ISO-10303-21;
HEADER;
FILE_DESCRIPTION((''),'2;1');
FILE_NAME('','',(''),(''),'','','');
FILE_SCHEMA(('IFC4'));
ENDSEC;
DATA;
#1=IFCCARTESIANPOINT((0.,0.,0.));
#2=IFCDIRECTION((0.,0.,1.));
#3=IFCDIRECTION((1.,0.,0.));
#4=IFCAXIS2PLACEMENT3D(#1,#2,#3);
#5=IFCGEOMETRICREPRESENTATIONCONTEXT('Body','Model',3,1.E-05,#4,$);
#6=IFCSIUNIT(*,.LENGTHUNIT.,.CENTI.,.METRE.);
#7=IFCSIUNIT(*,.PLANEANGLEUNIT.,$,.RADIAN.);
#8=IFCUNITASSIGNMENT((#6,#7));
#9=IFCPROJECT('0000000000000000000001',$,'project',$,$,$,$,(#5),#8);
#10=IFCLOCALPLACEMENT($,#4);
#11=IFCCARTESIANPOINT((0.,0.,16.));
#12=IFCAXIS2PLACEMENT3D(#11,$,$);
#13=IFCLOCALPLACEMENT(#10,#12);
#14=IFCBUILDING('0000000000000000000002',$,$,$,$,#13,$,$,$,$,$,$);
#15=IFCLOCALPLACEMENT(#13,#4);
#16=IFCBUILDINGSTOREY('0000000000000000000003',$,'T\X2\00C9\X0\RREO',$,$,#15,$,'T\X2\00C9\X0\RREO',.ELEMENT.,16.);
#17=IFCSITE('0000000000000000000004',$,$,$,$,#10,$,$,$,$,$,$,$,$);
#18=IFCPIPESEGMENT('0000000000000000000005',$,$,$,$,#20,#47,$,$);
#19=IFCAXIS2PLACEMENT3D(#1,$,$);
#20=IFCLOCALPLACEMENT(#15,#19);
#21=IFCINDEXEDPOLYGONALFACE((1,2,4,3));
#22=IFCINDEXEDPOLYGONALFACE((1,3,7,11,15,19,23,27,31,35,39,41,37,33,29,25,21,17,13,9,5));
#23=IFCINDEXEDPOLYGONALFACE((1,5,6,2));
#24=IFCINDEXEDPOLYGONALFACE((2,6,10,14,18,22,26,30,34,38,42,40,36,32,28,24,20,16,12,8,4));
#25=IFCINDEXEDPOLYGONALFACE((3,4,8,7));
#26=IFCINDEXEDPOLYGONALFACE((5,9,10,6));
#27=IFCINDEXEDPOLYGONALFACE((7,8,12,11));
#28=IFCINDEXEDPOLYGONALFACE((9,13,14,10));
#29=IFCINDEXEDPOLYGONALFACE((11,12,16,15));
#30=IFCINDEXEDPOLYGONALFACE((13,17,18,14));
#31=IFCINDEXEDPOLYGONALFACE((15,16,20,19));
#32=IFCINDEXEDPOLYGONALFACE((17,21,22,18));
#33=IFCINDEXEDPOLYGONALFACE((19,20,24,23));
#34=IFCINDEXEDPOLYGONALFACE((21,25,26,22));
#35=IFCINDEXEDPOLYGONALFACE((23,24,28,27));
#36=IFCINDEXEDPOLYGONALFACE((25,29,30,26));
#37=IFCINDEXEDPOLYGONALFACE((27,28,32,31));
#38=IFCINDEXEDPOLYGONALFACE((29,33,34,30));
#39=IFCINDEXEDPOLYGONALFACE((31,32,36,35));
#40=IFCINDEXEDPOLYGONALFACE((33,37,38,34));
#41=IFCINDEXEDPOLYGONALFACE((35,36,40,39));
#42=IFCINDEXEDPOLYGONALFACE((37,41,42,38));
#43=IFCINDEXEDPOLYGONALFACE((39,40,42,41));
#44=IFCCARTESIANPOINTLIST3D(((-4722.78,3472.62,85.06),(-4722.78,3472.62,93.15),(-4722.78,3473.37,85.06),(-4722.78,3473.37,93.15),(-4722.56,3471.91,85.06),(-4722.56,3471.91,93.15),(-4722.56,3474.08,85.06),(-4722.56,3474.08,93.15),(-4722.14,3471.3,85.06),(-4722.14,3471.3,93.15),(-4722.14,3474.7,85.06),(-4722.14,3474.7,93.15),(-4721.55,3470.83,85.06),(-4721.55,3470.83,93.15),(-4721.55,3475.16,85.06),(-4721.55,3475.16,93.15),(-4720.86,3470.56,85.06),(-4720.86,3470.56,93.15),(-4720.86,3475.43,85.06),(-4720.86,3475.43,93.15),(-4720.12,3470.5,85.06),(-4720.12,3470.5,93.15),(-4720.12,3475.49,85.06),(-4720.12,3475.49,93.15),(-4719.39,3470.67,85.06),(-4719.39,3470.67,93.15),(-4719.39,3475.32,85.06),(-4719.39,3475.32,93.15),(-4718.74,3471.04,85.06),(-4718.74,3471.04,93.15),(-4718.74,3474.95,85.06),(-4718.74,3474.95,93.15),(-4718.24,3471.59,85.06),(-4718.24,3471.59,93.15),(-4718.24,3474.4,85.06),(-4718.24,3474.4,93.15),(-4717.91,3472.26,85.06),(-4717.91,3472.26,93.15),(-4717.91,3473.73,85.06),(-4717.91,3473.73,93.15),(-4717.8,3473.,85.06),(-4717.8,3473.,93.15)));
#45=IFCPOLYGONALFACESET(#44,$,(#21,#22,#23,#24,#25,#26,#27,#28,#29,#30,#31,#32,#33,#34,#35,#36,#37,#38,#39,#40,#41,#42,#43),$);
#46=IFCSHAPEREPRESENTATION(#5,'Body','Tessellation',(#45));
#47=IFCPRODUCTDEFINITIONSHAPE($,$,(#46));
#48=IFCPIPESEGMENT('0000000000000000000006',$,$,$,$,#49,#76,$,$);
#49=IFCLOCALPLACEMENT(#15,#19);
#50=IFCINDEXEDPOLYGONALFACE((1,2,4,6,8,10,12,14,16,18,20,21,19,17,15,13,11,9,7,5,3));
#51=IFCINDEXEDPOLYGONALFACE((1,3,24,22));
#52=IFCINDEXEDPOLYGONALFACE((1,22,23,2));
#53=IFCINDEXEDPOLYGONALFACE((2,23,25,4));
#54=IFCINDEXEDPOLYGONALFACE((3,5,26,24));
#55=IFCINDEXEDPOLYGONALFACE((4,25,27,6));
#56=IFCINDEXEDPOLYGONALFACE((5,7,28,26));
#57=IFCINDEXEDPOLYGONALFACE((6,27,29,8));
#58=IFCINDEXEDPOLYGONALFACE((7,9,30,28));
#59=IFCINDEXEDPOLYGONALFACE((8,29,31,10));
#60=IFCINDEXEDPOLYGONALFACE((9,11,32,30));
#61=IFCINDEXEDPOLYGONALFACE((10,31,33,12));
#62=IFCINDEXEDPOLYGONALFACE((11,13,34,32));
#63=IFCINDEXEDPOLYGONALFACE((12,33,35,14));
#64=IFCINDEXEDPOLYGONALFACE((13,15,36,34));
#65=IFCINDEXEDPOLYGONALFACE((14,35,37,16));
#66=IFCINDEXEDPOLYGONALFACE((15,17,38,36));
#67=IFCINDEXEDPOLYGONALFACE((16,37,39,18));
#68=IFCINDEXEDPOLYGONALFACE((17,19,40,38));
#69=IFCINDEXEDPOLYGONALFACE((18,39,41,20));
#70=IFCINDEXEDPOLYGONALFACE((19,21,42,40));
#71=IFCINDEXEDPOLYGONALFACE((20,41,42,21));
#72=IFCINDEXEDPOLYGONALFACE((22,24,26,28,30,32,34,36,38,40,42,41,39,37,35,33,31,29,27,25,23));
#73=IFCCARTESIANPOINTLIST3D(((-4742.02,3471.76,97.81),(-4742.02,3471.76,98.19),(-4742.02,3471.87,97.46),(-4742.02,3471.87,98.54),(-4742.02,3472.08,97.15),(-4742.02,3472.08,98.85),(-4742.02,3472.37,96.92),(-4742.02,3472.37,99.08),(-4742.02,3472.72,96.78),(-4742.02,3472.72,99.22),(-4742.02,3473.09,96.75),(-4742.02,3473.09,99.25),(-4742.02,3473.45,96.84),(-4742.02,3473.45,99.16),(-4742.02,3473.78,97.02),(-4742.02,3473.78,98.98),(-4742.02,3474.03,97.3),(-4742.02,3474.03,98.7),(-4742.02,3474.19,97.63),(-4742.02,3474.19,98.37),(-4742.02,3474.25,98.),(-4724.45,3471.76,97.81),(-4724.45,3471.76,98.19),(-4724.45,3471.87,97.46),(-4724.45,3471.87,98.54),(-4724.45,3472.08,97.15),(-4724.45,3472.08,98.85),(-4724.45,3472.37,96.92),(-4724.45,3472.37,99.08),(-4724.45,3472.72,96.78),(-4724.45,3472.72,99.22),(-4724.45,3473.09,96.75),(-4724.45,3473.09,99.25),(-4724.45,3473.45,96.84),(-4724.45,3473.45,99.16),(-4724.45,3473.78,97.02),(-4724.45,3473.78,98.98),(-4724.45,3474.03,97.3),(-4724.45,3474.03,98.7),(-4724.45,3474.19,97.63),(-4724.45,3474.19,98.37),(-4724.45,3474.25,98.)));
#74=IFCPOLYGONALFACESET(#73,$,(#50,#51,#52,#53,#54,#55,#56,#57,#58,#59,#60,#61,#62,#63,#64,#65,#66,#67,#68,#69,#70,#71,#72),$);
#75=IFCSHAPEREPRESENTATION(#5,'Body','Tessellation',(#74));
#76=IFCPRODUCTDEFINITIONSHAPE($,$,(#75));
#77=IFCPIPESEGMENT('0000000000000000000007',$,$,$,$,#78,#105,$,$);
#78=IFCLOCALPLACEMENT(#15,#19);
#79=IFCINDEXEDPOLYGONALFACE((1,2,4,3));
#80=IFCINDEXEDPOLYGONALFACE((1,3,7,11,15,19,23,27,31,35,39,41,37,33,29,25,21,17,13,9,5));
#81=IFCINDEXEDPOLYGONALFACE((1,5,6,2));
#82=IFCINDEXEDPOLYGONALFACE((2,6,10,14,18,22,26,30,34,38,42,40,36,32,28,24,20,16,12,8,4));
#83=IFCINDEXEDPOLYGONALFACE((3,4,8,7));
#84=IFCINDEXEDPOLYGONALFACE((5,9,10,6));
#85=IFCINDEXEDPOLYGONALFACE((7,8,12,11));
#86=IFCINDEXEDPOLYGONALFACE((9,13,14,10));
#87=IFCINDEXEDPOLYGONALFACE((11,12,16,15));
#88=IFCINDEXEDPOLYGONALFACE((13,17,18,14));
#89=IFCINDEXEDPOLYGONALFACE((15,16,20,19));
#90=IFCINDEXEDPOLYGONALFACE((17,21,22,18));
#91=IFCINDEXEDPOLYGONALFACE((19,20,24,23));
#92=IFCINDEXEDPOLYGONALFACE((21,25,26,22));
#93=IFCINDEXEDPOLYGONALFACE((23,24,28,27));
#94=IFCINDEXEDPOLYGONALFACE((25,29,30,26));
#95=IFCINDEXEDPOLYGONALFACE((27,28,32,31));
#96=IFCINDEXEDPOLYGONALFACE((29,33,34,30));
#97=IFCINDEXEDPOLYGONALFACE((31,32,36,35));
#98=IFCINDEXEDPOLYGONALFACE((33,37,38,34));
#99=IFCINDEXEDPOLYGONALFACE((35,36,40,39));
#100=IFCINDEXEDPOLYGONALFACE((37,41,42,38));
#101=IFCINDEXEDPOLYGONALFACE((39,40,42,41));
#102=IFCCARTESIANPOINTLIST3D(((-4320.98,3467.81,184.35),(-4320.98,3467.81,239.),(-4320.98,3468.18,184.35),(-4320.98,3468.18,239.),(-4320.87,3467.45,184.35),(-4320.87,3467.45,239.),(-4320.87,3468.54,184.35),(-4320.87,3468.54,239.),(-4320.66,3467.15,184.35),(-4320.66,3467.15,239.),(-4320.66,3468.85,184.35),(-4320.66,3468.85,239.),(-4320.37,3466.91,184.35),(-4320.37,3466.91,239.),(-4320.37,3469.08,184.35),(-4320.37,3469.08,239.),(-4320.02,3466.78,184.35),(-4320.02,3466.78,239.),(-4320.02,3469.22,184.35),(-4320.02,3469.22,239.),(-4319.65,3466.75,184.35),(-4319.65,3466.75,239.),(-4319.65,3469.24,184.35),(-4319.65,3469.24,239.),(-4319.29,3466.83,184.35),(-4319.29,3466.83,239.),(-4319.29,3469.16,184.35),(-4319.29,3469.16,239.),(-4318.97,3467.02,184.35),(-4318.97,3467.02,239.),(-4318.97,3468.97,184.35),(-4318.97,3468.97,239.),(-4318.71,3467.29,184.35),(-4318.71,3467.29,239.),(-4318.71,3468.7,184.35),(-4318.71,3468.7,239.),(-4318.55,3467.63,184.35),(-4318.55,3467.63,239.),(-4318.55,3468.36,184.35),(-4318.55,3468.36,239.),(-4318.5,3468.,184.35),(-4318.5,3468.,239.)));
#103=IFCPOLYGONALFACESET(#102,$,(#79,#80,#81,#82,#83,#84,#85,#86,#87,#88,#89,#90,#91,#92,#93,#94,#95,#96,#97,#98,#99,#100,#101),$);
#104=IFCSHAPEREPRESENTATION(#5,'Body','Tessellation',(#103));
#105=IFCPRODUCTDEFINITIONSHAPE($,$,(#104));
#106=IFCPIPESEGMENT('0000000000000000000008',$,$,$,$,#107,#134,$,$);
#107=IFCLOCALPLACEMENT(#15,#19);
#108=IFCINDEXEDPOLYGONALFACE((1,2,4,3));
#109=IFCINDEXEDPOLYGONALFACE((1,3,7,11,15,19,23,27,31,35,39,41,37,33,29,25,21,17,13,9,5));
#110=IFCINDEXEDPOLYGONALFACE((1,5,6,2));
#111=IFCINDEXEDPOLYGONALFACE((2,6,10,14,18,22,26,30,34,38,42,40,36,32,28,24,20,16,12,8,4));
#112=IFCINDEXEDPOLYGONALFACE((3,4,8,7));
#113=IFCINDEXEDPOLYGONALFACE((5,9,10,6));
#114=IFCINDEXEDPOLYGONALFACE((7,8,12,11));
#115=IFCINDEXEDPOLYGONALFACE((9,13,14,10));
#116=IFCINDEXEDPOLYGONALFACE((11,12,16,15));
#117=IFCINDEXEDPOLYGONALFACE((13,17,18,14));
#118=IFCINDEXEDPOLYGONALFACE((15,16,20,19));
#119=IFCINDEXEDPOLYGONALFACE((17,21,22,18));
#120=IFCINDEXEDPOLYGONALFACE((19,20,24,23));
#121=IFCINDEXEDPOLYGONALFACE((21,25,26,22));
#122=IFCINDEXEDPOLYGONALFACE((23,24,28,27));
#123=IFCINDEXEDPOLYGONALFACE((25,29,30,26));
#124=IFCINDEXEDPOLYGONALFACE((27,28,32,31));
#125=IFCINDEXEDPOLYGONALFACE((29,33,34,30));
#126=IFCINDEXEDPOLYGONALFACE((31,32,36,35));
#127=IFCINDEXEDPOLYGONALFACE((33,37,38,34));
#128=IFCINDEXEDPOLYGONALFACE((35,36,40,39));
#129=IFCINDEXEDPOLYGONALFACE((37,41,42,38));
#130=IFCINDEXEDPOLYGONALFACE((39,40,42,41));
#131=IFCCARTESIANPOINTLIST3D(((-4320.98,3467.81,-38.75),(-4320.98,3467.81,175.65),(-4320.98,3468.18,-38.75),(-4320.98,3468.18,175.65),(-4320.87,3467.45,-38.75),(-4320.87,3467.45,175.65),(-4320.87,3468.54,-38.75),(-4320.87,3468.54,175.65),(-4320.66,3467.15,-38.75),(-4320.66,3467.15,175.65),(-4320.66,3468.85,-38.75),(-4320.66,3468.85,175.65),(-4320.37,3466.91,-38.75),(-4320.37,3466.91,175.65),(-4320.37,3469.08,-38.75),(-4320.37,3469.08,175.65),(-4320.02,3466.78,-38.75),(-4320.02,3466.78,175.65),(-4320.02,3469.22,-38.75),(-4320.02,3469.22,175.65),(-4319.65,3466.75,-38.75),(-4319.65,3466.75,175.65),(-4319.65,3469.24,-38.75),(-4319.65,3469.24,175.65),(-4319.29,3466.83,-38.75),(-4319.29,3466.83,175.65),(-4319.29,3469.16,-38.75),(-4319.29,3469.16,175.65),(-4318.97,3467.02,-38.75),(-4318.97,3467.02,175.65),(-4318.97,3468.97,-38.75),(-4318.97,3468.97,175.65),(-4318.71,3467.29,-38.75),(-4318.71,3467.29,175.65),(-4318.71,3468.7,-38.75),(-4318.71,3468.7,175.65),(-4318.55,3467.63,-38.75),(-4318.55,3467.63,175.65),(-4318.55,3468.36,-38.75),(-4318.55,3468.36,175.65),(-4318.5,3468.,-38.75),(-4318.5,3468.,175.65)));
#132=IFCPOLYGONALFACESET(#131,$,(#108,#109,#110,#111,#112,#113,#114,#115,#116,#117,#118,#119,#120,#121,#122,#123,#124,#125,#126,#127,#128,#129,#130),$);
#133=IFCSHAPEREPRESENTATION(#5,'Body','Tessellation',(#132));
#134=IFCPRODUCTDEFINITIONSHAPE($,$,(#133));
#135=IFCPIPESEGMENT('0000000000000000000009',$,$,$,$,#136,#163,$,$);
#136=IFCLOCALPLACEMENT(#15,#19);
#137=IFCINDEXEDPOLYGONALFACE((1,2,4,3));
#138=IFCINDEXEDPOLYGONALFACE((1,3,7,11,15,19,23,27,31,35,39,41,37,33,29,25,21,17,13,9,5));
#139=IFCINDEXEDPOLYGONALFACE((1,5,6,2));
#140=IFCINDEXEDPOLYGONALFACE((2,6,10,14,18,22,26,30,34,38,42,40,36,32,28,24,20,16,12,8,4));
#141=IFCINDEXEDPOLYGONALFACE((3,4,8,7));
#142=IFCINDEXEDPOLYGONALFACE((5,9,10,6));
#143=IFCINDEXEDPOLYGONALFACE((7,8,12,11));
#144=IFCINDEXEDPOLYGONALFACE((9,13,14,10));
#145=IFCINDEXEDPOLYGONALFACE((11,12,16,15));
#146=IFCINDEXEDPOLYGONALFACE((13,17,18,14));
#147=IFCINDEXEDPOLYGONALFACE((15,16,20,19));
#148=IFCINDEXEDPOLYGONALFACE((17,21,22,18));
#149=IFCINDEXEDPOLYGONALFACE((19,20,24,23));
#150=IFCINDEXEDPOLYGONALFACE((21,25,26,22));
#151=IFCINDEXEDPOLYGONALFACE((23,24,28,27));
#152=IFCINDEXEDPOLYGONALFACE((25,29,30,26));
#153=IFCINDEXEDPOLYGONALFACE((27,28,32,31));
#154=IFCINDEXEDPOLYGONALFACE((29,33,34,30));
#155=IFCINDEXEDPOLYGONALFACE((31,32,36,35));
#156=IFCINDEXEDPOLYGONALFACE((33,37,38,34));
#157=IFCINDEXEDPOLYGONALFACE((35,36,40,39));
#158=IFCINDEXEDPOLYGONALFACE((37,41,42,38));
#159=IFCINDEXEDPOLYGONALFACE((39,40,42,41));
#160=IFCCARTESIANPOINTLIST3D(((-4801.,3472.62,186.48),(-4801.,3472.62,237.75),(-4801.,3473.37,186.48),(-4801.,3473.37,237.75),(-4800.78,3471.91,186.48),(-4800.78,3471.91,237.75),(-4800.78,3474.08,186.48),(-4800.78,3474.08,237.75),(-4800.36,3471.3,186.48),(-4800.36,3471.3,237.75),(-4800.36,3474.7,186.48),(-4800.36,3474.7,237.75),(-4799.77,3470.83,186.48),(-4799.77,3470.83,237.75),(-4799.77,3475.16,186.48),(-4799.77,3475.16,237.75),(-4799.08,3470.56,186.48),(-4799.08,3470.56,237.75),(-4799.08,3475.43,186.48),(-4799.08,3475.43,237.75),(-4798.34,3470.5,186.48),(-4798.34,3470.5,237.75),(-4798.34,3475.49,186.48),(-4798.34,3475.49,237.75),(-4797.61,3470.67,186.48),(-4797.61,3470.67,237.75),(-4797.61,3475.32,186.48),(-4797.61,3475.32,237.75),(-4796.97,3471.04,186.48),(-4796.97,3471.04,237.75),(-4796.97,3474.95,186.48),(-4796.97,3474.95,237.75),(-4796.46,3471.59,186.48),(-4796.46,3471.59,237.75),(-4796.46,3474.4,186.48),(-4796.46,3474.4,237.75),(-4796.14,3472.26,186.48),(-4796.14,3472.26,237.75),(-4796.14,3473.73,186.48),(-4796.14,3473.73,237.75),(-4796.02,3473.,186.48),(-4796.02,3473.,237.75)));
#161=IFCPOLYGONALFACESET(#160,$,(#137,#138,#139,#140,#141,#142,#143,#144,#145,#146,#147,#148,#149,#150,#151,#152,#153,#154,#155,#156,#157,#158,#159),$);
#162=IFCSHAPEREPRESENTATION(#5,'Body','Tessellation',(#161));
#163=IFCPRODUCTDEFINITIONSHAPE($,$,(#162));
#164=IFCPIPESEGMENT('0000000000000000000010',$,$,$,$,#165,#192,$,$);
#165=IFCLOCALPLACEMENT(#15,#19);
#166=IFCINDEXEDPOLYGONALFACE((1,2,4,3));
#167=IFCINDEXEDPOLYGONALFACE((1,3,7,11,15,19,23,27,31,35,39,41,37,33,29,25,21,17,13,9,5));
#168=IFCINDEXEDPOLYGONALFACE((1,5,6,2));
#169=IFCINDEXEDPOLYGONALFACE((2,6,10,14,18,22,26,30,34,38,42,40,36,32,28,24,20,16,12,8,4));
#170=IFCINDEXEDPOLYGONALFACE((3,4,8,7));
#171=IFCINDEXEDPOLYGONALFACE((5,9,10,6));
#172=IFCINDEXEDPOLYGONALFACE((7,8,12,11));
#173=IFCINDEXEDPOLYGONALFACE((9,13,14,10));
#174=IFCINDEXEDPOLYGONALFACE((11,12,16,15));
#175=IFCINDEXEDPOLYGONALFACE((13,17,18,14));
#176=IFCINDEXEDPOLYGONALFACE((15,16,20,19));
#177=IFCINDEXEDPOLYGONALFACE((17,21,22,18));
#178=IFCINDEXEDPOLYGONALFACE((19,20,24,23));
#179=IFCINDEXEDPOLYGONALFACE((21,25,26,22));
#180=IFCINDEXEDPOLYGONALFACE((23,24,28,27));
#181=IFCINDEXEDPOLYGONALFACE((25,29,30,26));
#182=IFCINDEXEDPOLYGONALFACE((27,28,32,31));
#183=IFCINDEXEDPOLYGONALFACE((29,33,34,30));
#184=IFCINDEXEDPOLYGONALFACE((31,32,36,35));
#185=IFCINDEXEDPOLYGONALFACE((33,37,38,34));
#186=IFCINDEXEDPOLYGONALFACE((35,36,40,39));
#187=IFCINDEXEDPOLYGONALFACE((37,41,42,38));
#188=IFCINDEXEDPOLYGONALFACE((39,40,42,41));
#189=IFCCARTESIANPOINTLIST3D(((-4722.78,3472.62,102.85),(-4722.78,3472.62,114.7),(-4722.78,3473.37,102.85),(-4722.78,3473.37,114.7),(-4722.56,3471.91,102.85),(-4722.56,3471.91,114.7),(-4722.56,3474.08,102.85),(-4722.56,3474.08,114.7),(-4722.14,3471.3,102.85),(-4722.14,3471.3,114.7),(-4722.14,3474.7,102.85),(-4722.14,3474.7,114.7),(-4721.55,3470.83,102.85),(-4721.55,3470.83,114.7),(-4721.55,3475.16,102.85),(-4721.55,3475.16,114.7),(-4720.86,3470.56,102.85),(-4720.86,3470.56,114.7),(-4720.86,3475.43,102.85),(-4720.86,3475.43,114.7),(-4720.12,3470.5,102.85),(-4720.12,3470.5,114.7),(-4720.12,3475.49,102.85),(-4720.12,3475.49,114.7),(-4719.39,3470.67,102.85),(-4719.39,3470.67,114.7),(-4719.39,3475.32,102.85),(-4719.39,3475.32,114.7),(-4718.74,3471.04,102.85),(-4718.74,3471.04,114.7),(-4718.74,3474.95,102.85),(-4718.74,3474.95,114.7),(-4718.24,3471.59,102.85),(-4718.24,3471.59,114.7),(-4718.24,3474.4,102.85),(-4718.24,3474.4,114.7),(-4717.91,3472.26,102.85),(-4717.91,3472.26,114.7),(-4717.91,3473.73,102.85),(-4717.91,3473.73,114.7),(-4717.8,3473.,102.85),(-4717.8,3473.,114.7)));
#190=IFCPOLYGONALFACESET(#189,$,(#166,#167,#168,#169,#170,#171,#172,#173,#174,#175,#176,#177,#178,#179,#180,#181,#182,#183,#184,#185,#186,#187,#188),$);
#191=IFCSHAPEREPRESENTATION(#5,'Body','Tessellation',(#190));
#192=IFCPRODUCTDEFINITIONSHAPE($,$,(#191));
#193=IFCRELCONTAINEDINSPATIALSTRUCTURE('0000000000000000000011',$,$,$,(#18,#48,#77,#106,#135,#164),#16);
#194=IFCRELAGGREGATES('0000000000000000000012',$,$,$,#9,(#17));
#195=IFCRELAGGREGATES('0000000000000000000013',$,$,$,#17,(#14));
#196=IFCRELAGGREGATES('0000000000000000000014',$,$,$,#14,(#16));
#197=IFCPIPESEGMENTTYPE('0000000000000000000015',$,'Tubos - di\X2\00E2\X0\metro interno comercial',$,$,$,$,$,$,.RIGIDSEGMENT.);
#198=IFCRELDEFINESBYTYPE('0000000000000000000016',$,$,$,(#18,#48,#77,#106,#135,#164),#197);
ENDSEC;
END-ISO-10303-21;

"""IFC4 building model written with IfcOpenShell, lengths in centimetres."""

from ifc_helpers import new_model, si_unit, frame, origin_with_axes, origin_2d_with_axis, place, context, project, spatial, circle, extrude, type_object, element, save


model = new_model("IFC4")

# Units and contexts
model_context = context("Model", 3, precision=1e-05, world=origin_with_axes(), identifier="Body")
ifc_project = project(units=[si_unit("LENGTHUNIT", "METRE", prefix="CENTI"), si_unit("PLANEANGLEUNIT", "RADIAN")], contexts=[model_context])

# Site, building, storey
site_placement = place(None, origin_with_axes())
site = spatial("IfcSite", under=ifc_project, at=site_placement)
building_placement = place(site_placement, frame((0.0, 0.0, 16.0)))
building = spatial("IfcBuilding", under=site, at=building_placement)
storey_placement = place(building_placement, origin_with_axes())
storey = spatial("IfcBuildingStorey", under=building, at=storey_placement, Name="TÉRREO", LongName="TÉRREO", CompositionType="ELEMENT", Elevation=16.0)

# Pipe segments
pipe_segment_type = type_object("IfcPipeSegmentType", Name="Tubos - diâmetro interno comercial", PredefinedType="RIGIDSEGMENT")
pipe_segment_1_placement = place(storey_placement, frame((-4720.3, 3473.0, 93.15), z_axis=(0.0, 0.0, 1.0), x_axis=(1.0, 0.0, 0.0)))
element("IfcPipeSegment", 1, at=pipe_segment_1_placement, inside=storey, type_object=pipe_segment_type, context=model_context, shape_type="SolidModel", body=[
    extrude(circle(Radius=2.5, at=origin_2d_with_axis()), frame((0.0, 0.0, 0.0), z_axis=(0.0, 0.0, -1.0), x_axis=(1.0, 0.0, 0.0)), (0.0, 0.0, 1.0), 8.09),
])
pipe_segment_2_placement = place(storey_placement, frame((-4733.23, 3473.0, 99.25), z_axis=(0.0, 0.0, 1.0), x_axis=(1.0, 0.0, 0.0)))
element("IfcPipeSegment", 2, at=pipe_segment_2_placement, inside=storey, type_object=pipe_segment_type, context=model_context, shape_type="SolidModel", body=[
    extrude(circle(Radius=1.25, at=origin_2d_with_axis()), frame((8.78, 0.0, -1.25), z_axis=(-1.0, 0.0, 0.0), x_axis=(0.0, 1.0, 0.0)), (0.0, 0.0, 1.0), 17.56),
])
pipe_segment_3_placement = place(storey_placement, frame((-4319.75, 3468.0, 239.0), z_axis=(0.0, 0.0, 1.0), x_axis=(1.0, 0.0, 0.0)))
element("IfcPipeSegment", 3, at=pipe_segment_3_placement, inside=storey, type_object=pipe_segment_type, context=model_context, shape_type="SolidModel", body=[
    extrude(circle(Radius=1.25, at=origin_2d_with_axis()), frame((0.0, 0.0, 0.0), z_axis=(0.0, 0.0, -1.0), x_axis=(1.0, 0.0, 0.0)), (0.0, 0.0, 1.0), 54.65),
])
pipe_segment_4_placement = place(storey_placement, frame((-4319.75, 3468.0, 175.65), z_axis=(0.0, 0.0, 1.0), x_axis=(1.0, 0.0, 0.0)))
element("IfcPipeSegment", 4, at=pipe_segment_4_placement, inside=storey, type_object=pipe_segment_type, context=model_context, shape_type="SolidModel", body=[
    extrude(circle(Radius=1.25, at=origin_2d_with_axis()), frame((0.0, 0.0, 0.0), z_axis=(0.0, 0.0, -1.0), x_axis=(1.0, 0.0, 0.0)), (0.0, 0.0, 1.0), 214.4),
])
pipe_segment_5_placement = place(storey_placement, frame((-4798.52, 3473.0, 237.75), z_axis=(0.0, 0.0, 1.0), x_axis=(1.0, 0.0, 0.0)))
element("IfcPipeSegment", 5, at=pipe_segment_5_placement, inside=storey, type_object=pipe_segment_type, context=model_context, shape_type="SolidModel", body=[
    extrude(circle(Radius=2.5, at=origin_2d_with_axis()), frame((0.0, 0.0, 0.0), z_axis=(0.0, 0.0, -1.0), x_axis=(1.0, 0.0, 0.0)), (0.0, 0.0, 1.0), 51.27),
])
pipe_segment_6_placement = place(storey_placement, frame((-4720.3, 3473.0, 114.7), z_axis=(0.0, 0.0, 1.0), x_axis=(1.0, 0.0, 0.0)))
element("IfcPipeSegment", 6, at=pipe_segment_6_placement, inside=storey, type_object=pipe_segment_type, context=model_context, shape_type="SolidModel", body=[
    extrude(circle(Radius=2.5, at=origin_2d_with_axis()), frame((0.0, 0.0, 0.0), z_axis=(0.0, 0.0, -1.0), x_axis=(1.0, 0.0, 0.0)), (0.0, 0.0, 1.0), 11.85),
])

save(model, "model.ifc")
